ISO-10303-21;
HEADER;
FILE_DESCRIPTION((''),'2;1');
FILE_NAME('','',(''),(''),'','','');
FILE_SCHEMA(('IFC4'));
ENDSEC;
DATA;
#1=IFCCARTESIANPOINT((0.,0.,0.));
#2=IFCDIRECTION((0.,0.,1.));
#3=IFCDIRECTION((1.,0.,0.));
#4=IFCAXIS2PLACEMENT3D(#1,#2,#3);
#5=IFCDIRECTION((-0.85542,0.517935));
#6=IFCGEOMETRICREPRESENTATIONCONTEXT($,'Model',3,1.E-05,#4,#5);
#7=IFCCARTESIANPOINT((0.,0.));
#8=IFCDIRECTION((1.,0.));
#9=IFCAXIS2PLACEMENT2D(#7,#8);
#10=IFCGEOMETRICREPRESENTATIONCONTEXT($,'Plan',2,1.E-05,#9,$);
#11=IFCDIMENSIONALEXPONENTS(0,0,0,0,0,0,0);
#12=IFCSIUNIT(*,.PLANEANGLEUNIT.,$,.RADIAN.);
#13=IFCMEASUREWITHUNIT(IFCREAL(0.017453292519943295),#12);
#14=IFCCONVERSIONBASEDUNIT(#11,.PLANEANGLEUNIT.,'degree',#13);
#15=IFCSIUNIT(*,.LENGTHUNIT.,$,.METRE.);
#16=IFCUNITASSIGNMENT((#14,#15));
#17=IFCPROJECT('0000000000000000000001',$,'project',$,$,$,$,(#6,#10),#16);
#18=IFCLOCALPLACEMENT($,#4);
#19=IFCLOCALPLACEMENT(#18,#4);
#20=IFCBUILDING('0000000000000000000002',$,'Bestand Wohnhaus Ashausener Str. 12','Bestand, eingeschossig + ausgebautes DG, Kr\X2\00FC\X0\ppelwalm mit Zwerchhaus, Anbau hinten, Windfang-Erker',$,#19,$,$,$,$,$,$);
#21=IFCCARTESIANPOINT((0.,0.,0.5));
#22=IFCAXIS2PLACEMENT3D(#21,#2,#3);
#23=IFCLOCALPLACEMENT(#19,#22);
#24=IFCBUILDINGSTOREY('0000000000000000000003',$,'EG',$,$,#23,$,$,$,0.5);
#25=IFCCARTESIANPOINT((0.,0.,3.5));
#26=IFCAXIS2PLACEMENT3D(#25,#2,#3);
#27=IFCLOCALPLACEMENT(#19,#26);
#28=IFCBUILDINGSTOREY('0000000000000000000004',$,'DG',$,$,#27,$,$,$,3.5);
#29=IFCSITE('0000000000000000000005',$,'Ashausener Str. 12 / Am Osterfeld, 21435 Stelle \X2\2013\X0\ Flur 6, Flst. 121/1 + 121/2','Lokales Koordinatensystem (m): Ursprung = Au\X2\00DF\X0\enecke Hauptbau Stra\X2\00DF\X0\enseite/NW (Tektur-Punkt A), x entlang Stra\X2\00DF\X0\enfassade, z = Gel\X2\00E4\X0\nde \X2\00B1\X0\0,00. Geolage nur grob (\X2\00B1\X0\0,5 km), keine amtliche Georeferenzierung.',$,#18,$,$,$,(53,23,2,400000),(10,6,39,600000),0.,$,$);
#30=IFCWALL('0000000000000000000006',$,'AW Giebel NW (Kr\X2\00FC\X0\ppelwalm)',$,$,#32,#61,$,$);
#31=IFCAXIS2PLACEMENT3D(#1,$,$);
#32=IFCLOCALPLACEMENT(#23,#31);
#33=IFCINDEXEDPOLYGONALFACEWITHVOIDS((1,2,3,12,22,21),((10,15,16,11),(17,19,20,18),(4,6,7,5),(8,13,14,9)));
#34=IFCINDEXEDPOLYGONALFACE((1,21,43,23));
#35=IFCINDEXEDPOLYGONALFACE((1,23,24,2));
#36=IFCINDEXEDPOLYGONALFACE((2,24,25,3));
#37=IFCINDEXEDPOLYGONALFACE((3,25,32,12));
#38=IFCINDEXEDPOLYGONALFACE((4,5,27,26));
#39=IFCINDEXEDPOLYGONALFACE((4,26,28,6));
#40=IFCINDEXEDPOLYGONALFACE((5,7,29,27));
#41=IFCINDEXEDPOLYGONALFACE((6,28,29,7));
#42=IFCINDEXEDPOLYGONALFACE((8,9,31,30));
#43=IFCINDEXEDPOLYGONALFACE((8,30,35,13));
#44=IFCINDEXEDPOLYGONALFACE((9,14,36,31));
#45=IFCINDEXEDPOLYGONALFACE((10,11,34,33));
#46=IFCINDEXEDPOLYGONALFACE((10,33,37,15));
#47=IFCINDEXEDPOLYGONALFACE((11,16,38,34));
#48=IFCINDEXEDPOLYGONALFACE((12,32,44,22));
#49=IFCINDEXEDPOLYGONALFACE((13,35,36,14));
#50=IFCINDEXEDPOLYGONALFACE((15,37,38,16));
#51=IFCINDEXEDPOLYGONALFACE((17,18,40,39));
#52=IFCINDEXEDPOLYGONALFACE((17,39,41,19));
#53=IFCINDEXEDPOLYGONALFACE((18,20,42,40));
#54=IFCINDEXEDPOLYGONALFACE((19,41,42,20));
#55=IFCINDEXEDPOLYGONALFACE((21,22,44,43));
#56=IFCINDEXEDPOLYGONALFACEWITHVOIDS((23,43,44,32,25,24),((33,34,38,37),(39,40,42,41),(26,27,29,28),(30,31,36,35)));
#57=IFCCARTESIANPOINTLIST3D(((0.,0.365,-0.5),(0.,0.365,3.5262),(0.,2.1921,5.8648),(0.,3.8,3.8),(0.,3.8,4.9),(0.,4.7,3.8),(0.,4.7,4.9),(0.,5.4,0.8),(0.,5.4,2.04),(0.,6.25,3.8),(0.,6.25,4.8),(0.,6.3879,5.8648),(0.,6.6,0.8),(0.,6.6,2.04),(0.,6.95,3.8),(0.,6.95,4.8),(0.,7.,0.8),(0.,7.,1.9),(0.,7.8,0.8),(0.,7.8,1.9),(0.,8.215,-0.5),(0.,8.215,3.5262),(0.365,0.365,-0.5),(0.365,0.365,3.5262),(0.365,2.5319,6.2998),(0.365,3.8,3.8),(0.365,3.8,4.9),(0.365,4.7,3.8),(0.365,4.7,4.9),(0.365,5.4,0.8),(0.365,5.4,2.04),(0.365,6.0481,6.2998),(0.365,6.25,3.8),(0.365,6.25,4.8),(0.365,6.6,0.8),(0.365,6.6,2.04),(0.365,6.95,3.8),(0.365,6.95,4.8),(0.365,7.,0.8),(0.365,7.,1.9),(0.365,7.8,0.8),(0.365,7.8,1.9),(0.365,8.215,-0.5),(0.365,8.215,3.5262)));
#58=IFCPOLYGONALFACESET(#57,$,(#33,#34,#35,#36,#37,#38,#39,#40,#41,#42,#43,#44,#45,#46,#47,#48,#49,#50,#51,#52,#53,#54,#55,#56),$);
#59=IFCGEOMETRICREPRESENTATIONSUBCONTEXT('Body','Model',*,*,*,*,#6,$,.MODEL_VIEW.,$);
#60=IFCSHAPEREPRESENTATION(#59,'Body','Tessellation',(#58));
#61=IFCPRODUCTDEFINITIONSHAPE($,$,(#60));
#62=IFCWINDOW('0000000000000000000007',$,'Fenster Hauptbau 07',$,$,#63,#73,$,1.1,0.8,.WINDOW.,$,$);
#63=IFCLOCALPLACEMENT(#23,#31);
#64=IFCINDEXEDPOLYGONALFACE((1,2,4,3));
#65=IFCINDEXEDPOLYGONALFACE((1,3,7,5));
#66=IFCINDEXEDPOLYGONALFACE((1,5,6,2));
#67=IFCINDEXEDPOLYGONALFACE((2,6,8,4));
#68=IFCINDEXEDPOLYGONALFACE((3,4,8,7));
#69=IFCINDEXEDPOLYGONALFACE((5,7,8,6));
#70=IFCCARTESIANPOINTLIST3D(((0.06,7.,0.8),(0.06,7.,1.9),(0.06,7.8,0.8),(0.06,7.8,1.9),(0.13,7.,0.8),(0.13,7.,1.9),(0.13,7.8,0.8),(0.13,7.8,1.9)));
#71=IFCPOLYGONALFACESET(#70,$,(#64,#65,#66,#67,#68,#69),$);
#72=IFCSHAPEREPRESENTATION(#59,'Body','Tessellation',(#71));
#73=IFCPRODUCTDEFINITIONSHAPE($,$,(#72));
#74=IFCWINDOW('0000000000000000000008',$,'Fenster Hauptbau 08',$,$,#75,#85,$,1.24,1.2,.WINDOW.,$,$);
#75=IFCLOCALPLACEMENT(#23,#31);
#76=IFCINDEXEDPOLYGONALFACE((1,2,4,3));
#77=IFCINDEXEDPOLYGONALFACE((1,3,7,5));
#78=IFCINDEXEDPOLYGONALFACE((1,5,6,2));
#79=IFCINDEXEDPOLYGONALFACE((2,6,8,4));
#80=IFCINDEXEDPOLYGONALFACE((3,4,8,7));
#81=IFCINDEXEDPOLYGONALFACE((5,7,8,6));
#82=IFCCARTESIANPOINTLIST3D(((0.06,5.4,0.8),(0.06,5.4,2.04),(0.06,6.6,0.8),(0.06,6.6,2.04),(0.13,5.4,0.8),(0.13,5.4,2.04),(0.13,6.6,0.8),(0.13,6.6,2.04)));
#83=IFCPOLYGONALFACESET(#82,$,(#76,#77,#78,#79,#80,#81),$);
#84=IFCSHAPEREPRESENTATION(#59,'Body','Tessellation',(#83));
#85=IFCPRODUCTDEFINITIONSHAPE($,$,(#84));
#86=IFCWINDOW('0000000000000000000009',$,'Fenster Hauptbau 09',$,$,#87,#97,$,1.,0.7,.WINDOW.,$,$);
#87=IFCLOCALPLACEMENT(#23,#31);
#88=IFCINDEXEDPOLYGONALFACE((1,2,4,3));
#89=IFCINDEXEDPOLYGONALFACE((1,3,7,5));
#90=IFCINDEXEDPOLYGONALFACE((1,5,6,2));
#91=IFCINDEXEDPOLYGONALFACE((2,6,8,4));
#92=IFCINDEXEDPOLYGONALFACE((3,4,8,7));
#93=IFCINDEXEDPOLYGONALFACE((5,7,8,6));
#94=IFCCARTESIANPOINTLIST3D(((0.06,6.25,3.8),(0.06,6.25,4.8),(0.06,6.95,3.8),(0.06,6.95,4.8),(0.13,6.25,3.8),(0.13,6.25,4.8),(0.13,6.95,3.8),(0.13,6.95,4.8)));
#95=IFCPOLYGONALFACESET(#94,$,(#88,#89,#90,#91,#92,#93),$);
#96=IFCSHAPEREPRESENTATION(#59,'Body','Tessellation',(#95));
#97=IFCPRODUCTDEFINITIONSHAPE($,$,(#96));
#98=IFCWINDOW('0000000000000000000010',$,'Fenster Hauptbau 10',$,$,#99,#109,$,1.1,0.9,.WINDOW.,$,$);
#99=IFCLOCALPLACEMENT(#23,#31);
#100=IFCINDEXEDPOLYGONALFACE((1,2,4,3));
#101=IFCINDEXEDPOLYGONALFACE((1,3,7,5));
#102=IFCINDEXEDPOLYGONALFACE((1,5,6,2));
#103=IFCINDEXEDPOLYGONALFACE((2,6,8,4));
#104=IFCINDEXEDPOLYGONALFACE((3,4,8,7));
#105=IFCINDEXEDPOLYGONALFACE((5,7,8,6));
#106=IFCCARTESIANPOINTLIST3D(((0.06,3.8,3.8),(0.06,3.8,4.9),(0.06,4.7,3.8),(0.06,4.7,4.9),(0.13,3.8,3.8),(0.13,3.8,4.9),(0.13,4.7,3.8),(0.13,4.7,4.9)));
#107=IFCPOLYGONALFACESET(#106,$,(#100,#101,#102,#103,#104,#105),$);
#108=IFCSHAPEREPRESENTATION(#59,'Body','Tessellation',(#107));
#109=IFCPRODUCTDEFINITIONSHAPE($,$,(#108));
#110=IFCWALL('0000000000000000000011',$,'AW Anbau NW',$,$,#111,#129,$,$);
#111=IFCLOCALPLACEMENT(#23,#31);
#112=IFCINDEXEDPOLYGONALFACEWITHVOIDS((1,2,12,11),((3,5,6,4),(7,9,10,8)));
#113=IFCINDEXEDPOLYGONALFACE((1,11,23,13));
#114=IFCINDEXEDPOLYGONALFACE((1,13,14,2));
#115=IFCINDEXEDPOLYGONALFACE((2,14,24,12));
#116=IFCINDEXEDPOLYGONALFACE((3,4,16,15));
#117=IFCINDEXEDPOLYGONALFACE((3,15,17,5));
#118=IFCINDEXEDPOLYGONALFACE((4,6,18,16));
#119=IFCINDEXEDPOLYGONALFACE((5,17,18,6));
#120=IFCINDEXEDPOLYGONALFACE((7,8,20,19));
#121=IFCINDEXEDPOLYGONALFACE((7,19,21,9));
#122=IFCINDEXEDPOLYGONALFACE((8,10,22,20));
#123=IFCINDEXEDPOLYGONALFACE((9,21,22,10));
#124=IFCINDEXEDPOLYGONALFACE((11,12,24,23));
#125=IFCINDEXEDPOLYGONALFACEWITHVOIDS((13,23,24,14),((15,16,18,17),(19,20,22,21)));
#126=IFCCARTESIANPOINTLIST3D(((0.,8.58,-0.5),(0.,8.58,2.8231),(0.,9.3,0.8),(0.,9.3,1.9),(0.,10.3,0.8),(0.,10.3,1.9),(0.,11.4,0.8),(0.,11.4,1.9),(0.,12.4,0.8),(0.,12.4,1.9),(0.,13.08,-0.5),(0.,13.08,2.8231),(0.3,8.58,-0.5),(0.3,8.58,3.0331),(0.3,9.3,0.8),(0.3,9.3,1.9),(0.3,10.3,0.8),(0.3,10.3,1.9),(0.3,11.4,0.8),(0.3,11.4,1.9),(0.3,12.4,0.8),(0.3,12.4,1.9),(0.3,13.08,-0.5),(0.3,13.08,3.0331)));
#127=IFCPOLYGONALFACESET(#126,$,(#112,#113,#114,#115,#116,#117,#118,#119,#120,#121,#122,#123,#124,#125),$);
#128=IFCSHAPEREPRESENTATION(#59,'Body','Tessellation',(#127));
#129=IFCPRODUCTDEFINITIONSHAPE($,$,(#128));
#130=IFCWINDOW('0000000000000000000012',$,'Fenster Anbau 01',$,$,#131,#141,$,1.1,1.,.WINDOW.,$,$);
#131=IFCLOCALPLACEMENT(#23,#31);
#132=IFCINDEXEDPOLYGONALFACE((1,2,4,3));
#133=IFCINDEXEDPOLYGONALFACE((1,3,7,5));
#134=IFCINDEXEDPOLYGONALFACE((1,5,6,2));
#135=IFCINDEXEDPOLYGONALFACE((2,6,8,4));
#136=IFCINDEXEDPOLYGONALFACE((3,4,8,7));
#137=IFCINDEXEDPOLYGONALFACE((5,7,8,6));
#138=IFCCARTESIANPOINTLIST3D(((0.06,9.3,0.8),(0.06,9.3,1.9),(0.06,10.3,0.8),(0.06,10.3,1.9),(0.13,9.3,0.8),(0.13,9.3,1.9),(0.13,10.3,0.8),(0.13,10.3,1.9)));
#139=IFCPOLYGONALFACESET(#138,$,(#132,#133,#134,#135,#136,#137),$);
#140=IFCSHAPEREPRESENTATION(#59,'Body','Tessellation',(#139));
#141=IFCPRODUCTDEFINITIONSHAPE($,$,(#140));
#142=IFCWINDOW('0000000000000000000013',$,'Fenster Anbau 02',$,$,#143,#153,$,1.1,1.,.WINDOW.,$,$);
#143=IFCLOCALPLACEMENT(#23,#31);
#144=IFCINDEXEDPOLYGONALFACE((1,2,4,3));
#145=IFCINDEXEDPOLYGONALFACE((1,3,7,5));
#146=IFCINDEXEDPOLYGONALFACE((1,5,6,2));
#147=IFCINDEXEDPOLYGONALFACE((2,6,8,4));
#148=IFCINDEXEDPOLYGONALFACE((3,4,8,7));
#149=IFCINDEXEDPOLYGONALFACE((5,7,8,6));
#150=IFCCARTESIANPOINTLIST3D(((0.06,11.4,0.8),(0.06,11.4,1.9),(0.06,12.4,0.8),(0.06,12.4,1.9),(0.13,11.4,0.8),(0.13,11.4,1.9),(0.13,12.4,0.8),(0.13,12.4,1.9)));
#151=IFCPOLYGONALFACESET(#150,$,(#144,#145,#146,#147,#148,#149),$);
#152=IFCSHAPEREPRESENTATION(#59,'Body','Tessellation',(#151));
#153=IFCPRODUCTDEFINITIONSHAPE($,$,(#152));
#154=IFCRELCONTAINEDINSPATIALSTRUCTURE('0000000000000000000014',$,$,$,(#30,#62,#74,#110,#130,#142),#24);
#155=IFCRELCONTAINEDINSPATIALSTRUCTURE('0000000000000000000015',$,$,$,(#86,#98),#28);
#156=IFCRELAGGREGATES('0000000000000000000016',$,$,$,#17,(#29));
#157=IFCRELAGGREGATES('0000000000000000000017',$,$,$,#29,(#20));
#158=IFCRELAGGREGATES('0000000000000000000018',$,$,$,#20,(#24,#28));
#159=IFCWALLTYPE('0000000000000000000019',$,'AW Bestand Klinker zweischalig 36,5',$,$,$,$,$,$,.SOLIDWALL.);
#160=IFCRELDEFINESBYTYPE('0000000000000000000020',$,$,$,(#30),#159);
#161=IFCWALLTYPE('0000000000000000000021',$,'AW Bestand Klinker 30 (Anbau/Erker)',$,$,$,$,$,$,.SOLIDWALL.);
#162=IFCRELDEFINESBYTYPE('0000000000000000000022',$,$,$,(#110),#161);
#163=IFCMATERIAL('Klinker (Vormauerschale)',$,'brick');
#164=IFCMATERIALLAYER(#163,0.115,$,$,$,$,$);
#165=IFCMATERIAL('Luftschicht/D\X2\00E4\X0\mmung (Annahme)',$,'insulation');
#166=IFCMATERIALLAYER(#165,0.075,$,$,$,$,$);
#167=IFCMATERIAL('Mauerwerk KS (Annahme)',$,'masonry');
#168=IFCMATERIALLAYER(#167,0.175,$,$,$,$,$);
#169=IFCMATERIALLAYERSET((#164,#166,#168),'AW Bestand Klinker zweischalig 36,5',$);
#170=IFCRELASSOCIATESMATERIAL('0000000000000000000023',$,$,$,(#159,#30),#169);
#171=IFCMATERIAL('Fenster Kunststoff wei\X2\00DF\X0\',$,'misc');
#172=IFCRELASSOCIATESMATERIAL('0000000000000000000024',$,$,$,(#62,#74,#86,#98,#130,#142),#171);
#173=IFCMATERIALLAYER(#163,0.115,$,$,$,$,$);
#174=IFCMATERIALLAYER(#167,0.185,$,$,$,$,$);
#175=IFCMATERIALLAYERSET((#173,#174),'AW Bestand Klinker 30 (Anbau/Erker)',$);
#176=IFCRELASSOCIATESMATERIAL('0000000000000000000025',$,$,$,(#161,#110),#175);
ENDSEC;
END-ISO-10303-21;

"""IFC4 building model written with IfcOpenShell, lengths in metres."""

from ifc_helpers import new_model, entity, si_unit, converted_unit, direction, frame, origin_with_axes, origin_2d_with_axis, place, context, subcontext, project, spatial, indexed_curve, outline, extrude, clip, halfspace, material, layer, layer_set, layer_usage, type_object, element, fill, save


model = new_model("IFC4")

# Units and contexts
model_context = context("Model", 3, precision=1e-05, world=origin_with_axes(), true_north=direction((-0.85542, 0.517935)))
plan_context = context("Plan", 2, precision=1e-05, world=origin_2d_with_axis())
body_context = subcontext(model_context, "Body", "Model", "MODEL_VIEW")
ifc_project = project(units=[converted_unit("PLANEANGLEUNIT", "degree", entity("IfcReal", 0.017453292519943295), si_unit("PLANEANGLEUNIT", "RADIAN"), dimensions=[0, 0, 0, 0, 0, 0, 0]), si_unit("LENGTHUNIT", "METRE")], contexts=[model_context, plan_context])

# Site, building, storey
site_placement = place(None, origin_with_axes())
site = spatial("IfcSite", under=ifc_project, at=site_placement, Name="Ashausener Str. 12 / Am Osterfeld, 21435 Stelle – Flur 6, Flst. 121/1 + 121/2", Description="Lokales Koordinatensystem (m): Ursprung = Außenecke Hauptbau Straßenseite/NW (Tektur-Punkt A), x entlang Straßenfassade, z = Gelände ±0,00. Geolage nur grob (±0,5 km), keine amtliche Georeferenzierung.", RefLatitude=(53, 23, 2, 400000), RefLongitude=(10, 6, 39, 600000), RefElevation=0.0)
building_placement = place(site_placement, origin_with_axes())
building = spatial("IfcBuilding", under=site, at=building_placement, Name="Bestand Wohnhaus Ashausener Str. 12", Description="Bestand, eingeschossig + ausgebautes DG, Krüppelwalm mit Zwerchhaus, Anbau hinten, Windfang-Erker")
storey_1_placement = place(building_placement, frame((0.0, 0.0, 0.5), z_axis=(0.0, 0.0, 1.0), x_axis=(1.0, 0.0, 0.0)))
storey_1 = spatial("IfcBuildingStorey", under=building, at=storey_1_placement, Name="EG", Elevation=0.5)

# Wall, openings, windows
ifc_material_1 = material(Name="Klinker (Vormauerschale)", Category="brick")
ifc_layer_1 = layer(ifc_material_1, 0.115)
ifc_material_2 = material(Name="Luftschicht/Dämmung (Annahme)", Category="insulation")
ifc_layer_2 = layer(ifc_material_2, 0.075)
ifc_material_3 = material(Name="Mauerwerk KS (Annahme)", Category="masonry")
ifc_layer_3 = layer(ifc_material_3, 0.175)
ifc_layer_set_1 = layer_set([ifc_layer_1, ifc_layer_2, ifc_layer_3], Name="AW Bestand Klinker zweischalig 36,5")
ifc_layer_usage_1 = layer_usage(ifc_layer_set_1, "AXIS2", "POSITIVE", 0.0)
wall_type_1 = type_object("IfcWallType", Name="AW Bestand Klinker zweischalig 36,5", PredefinedType="SOLIDWALL", material=ifc_layer_set_1)
wall_1_placement = place(storey_1_placement, frame((0.0, 8.215, -0.5), z_axis=(0.0, 0.0, 1.0), x_axis=(0.0, -1.0, 0.0)))
wall_1 = element("IfcWall", 1, at=wall_1_placement, inside=storey_1, type_object=wall_type_1, material=ifc_layer_usage_1, Name="AW Giebel NW (Krüppelwalm)", context=body_context, shape_type="Clipping", body=[
    clip(clip(clip(clip(extrude(outline(indexed_curve([(0.0, 0.0), (0.0, 0.365), (7.85, 0.365), (7.85, 0.0), (0.0, 0.0)], self_intersect=False)), origin_with_axes(), (0.0, 0.0, 1.0), 12.0), halfspace(frame((8.215, 11.87, 5.9), z_axis=(0.0, 0.76604, 0.64279), x_axis=(1.0, 0.0, 0.0)), False)), halfspace(frame((8.215, -0.39, 5.9), z_axis=(0.0, -0.76604, 0.64279), x_axis=(-1.0, 0.0, 0.0)), False)), halfspace(frame((3.925, 0.0, 9.05), z_axis=(-0.78801, 0.0, 0.61566), x_axis=(0.0, 1.0, 0.0)), False)), halfspace(frame((3.925, 0.0, 9.05), z_axis=(0.78801, 0.0, 0.61566), x_axis=(0.0, -1.0, 0.0)), False)),
])
opening_1_placement = place(wall_1_placement, frame((0.415, -0.1, 1.3), z_axis=(0.0, 0.0, 1.0), x_axis=(1.0, 0.0, 0.0)))
opening_1 = element("IfcOpeningElement", 2, at=opening_1_placement, cuts=wall_1, context=body_context, shape_type="SweptSolid", body=[
    extrude(outline(indexed_curve([(0.0, 0.0), (0.0, 0.565), (0.8, 0.565), (0.8, 0.0), (0.0, 0.0)], self_intersect=False)), origin_with_axes(), (0.0, 0.0, 1.0), 1.1),
])
opening_2_placement = place(wall_1_placement, frame((1.615, -0.1, 1.3), z_axis=(0.0, 0.0, 1.0), x_axis=(1.0, 0.0, 0.0)))
opening_2 = element("IfcOpeningElement", 3, at=opening_2_placement, cuts=wall_1, context=body_context, shape_type="SweptSolid", body=[
    extrude(outline(indexed_curve([(0.0, 0.0), (0.0, 0.565), (1.2, 0.565), (1.2, 0.0), (0.0, 0.0)], self_intersect=False)), origin_with_axes(), (0.0, 0.0, 1.0), 1.24),
])
opening_3_placement = place(wall_1_placement, frame((1.265, -0.1, 4.3), z_axis=(0.0, 0.0, 1.0), x_axis=(1.0, 0.0, 0.0)))
opening_3 = element("IfcOpeningElement", 4, at=opening_3_placement, cuts=wall_1, context=body_context, shape_type="SweptSolid", body=[
    extrude(outline(indexed_curve([(0.0, 0.0), (0.0, 0.565), (0.7, 0.565), (0.7, 0.0), (0.0, 0.0)], self_intersect=False)), origin_with_axes(), (0.0, 0.0, 1.0), 1.0),
])
opening_4_placement = place(wall_1_placement, frame((3.515, -0.1, 4.3), z_axis=(0.0, 0.0, 1.0), x_axis=(1.0, 0.0, 0.0)))
opening_4 = element("IfcOpeningElement", 5, at=opening_4_placement, cuts=wall_1, context=body_context, shape_type="SweptSolid", body=[
    extrude(outline(indexed_curve([(0.0, 0.0), (0.0, 0.565), (0.9, 0.565), (0.9, 0.0), (0.0, 0.0)], self_intersect=False)), origin_with_axes(), (0.0, 0.0, 1.0), 1.1),
])
ifc_material_4 = material(Name="Fenster Kunststoff weiß", Category="misc")
window_1_placement = place(storey_1_placement, frame((0.06, 7.8, 0.8), z_axis=(0.0, 0.0, 1.0), x_axis=(0.0, -1.0, 0.0)))
window_1 = element("IfcWindow", 6, at=window_1_placement, inside=storey_1, material=ifc_material_4, Name="Fenster Hauptbau 07", OverallHeight=1.1, OverallWidth=0.8, PredefinedType="WINDOW", context=body_context, shape_type="SweptSolid", body=[
    extrude(outline(indexed_curve([(0.0, 0.0), (0.0, 0.07), (0.8, 0.07), (0.8, 0.0), (0.0, 0.0)], self_intersect=False)), origin_with_axes(), (0.0, 0.0, 1.0), 1.1),
])
fill(opening_1, window_1)
window_2_placement = place(storey_1_placement, frame((0.06, 6.6, 0.8), z_axis=(0.0, 0.0, 1.0), x_axis=(0.0, -1.0, 0.0)))
window_2 = element("IfcWindow", 7, at=window_2_placement, inside=storey_1, material=ifc_material_4, Name="Fenster Hauptbau 08", OverallHeight=1.24, OverallWidth=1.2, PredefinedType="WINDOW", context=body_context, shape_type="SweptSolid", body=[
    extrude(outline(indexed_curve([(0.0, 0.0), (0.0, 0.07), (1.2, 0.07), (1.2, 0.0), (0.0, 0.0)], self_intersect=False)), origin_with_axes(), (0.0, 0.0, 1.0), 1.24),
])
fill(opening_2, window_2)

# Shared definitions
storey_2_placement = place(building_placement, frame((0.0, 0.0, 3.5), z_axis=(0.0, 0.0, 1.0), x_axis=(1.0, 0.0, 0.0)))
storey_2 = spatial("IfcBuildingStorey", under=building, at=storey_2_placement, Name="DG", Elevation=3.5)

# Windows
window_3_placement = place(storey_2_placement, frame((0.06, 6.95, 0.8), z_axis=(0.0, 0.0, 1.0), x_axis=(0.0, -1.0, 0.0)))
window_3 = element("IfcWindow", 8, at=window_3_placement, inside=storey_2, material=ifc_material_4, Name="Fenster Hauptbau 09", OverallHeight=1.0, OverallWidth=0.7, PredefinedType="WINDOW", context=body_context, shape_type="SweptSolid", body=[
    extrude(outline(indexed_curve([(0.0, 0.0), (0.0, 0.07), (0.7, 0.07), (0.7, 0.0), (0.0, 0.0)], self_intersect=False)), origin_with_axes(), (0.0, 0.0, 1.0), 1.0),
])
fill(opening_3, window_3)
window_4_placement = place(storey_2_placement, frame((0.06, 4.7, 0.8), z_axis=(0.0, 0.0, 1.0), x_axis=(0.0, -1.0, 0.0)))
window_4 = element("IfcWindow", 9, at=window_4_placement, inside=storey_2, material=ifc_material_4, Name="Fenster Hauptbau 10", OverallHeight=1.1, OverallWidth=0.9, PredefinedType="WINDOW", context=body_context, shape_type="SweptSolid", body=[
    extrude(outline(indexed_curve([(0.0, 0.0), (0.0, 0.07), (0.9, 0.07), (0.9, 0.0), (0.0, 0.0)], self_intersect=False)), origin_with_axes(), (0.0, 0.0, 1.0), 1.1),
])
fill(opening_4, window_4)

# Wall, openings, windows
ifc_layer_4 = layer(ifc_material_1, 0.115)
ifc_layer_5 = layer(ifc_material_3, 0.185)
ifc_layer_set_2 = layer_set([ifc_layer_4, ifc_layer_5], Name="AW Bestand Klinker 30 (Anbau/Erker)")
ifc_layer_usage_2 = layer_usage(ifc_layer_set_2, "AXIS2", "POSITIVE", 0.0)
wall_type_2 = type_object("IfcWallType", Name="AW Bestand Klinker 30 (Anbau/Erker)", PredefinedType="SOLIDWALL", material=ifc_layer_set_2)
wall_2_placement = place(storey_1_placement, frame((0.0, 13.08, -0.5), z_axis=(0.0, 0.0, 1.0), x_axis=(0.0, -1.0, 0.0)))
wall_2 = element("IfcWall", 10, at=wall_2_placement, inside=storey_1, type_object=wall_type_2, material=ifc_layer_usage_2, Name="AW Anbau NW", context=body_context, shape_type="Clipping", body=[
    clip(clip(extrude(outline(indexed_curve([(0.0, 0.0), (0.0, 0.3), (4.5, 0.3), (4.5, 0.0), (0.0, 0.0)], self_intersect=False)), origin_with_axes(), (0.0, 0.0, 1.0), 8.0), halfspace(frame((13.08, 4.29, 3.05), z_axis=(0.0, 0.57358, 0.81915), x_axis=(1.0, 0.0, 0.0)), False)), halfspace(frame((13.08, -0.39, 3.05), z_axis=(0.0, -0.57358, 0.81915), x_axis=(-1.0, 0.0, 0.0)), False)),
])
opening_5_placement = place(wall_2_placement, frame((2.78, -0.1, 1.3), z_axis=(0.0, 0.0, 1.0), x_axis=(1.0, 0.0, 0.0)))
opening_5 = element("IfcOpeningElement", 11, at=opening_5_placement, cuts=wall_2, context=body_context, shape_type="SweptSolid", body=[
    extrude(outline(indexed_curve([(0.0, 0.0), (0.0, 0.5), (1.0, 0.5), (1.0, 0.0), (0.0, 0.0)], self_intersect=False)), origin_with_axes(), (0.0, 0.0, 1.0), 1.1),
])
opening_6_placement = place(wall_2_placement, frame((0.68, -0.1, 1.3), z_axis=(0.0, 0.0, 1.0), x_axis=(1.0, 0.0, 0.0)))
opening_6 = element("IfcOpeningElement", 12, at=opening_6_placement, cuts=wall_2, context=body_context, shape_type="SweptSolid", body=[
    extrude(outline(indexed_curve([(0.0, 0.0), (0.0, 0.5), (1.0, 0.5), (1.0, 0.0), (0.0, 0.0)], self_intersect=False)), origin_with_axes(), (0.0, 0.0, 1.0), 1.1),
])
window_5_placement = place(storey_1_placement, frame((0.06, 10.3, 0.8), z_axis=(0.0, 0.0, 1.0), x_axis=(0.0, -1.0, 0.0)))
window_5 = element("IfcWindow", 13, at=window_5_placement, inside=storey_1, material=ifc_material_4, Name="Fenster Anbau 01", OverallHeight=1.1, OverallWidth=1.0, PredefinedType="WINDOW", context=body_context, shape_type="SweptSolid", body=[
    extrude(outline(indexed_curve([(0.0, 0.0), (0.0, 0.07), (1.0, 0.07), (1.0, 0.0), (0.0, 0.0)], self_intersect=False)), origin_with_axes(), (0.0, 0.0, 1.0), 1.1),
])
fill(opening_5, window_5)
window_6_placement = place(storey_1_placement, frame((0.06, 12.4, 0.8), z_axis=(0.0, 0.0, 1.0), x_axis=(0.0, -1.0, 0.0)))
window_6 = element("IfcWindow", 14, at=window_6_placement, inside=storey_1, material=ifc_material_4, Name="Fenster Anbau 02", OverallHeight=1.1, OverallWidth=1.0, PredefinedType="WINDOW", context=body_context, shape_type="SweptSolid", body=[
    extrude(outline(indexed_curve([(0.0, 0.0), (0.0, 0.07), (1.0, 0.07), (1.0, 0.0), (0.0, 0.0)], self_intersect=False)), origin_with_axes(), (0.0, 0.0, 1.0), 1.1),
])
fill(opening_6, window_6)

save(model, "model.ifc")
